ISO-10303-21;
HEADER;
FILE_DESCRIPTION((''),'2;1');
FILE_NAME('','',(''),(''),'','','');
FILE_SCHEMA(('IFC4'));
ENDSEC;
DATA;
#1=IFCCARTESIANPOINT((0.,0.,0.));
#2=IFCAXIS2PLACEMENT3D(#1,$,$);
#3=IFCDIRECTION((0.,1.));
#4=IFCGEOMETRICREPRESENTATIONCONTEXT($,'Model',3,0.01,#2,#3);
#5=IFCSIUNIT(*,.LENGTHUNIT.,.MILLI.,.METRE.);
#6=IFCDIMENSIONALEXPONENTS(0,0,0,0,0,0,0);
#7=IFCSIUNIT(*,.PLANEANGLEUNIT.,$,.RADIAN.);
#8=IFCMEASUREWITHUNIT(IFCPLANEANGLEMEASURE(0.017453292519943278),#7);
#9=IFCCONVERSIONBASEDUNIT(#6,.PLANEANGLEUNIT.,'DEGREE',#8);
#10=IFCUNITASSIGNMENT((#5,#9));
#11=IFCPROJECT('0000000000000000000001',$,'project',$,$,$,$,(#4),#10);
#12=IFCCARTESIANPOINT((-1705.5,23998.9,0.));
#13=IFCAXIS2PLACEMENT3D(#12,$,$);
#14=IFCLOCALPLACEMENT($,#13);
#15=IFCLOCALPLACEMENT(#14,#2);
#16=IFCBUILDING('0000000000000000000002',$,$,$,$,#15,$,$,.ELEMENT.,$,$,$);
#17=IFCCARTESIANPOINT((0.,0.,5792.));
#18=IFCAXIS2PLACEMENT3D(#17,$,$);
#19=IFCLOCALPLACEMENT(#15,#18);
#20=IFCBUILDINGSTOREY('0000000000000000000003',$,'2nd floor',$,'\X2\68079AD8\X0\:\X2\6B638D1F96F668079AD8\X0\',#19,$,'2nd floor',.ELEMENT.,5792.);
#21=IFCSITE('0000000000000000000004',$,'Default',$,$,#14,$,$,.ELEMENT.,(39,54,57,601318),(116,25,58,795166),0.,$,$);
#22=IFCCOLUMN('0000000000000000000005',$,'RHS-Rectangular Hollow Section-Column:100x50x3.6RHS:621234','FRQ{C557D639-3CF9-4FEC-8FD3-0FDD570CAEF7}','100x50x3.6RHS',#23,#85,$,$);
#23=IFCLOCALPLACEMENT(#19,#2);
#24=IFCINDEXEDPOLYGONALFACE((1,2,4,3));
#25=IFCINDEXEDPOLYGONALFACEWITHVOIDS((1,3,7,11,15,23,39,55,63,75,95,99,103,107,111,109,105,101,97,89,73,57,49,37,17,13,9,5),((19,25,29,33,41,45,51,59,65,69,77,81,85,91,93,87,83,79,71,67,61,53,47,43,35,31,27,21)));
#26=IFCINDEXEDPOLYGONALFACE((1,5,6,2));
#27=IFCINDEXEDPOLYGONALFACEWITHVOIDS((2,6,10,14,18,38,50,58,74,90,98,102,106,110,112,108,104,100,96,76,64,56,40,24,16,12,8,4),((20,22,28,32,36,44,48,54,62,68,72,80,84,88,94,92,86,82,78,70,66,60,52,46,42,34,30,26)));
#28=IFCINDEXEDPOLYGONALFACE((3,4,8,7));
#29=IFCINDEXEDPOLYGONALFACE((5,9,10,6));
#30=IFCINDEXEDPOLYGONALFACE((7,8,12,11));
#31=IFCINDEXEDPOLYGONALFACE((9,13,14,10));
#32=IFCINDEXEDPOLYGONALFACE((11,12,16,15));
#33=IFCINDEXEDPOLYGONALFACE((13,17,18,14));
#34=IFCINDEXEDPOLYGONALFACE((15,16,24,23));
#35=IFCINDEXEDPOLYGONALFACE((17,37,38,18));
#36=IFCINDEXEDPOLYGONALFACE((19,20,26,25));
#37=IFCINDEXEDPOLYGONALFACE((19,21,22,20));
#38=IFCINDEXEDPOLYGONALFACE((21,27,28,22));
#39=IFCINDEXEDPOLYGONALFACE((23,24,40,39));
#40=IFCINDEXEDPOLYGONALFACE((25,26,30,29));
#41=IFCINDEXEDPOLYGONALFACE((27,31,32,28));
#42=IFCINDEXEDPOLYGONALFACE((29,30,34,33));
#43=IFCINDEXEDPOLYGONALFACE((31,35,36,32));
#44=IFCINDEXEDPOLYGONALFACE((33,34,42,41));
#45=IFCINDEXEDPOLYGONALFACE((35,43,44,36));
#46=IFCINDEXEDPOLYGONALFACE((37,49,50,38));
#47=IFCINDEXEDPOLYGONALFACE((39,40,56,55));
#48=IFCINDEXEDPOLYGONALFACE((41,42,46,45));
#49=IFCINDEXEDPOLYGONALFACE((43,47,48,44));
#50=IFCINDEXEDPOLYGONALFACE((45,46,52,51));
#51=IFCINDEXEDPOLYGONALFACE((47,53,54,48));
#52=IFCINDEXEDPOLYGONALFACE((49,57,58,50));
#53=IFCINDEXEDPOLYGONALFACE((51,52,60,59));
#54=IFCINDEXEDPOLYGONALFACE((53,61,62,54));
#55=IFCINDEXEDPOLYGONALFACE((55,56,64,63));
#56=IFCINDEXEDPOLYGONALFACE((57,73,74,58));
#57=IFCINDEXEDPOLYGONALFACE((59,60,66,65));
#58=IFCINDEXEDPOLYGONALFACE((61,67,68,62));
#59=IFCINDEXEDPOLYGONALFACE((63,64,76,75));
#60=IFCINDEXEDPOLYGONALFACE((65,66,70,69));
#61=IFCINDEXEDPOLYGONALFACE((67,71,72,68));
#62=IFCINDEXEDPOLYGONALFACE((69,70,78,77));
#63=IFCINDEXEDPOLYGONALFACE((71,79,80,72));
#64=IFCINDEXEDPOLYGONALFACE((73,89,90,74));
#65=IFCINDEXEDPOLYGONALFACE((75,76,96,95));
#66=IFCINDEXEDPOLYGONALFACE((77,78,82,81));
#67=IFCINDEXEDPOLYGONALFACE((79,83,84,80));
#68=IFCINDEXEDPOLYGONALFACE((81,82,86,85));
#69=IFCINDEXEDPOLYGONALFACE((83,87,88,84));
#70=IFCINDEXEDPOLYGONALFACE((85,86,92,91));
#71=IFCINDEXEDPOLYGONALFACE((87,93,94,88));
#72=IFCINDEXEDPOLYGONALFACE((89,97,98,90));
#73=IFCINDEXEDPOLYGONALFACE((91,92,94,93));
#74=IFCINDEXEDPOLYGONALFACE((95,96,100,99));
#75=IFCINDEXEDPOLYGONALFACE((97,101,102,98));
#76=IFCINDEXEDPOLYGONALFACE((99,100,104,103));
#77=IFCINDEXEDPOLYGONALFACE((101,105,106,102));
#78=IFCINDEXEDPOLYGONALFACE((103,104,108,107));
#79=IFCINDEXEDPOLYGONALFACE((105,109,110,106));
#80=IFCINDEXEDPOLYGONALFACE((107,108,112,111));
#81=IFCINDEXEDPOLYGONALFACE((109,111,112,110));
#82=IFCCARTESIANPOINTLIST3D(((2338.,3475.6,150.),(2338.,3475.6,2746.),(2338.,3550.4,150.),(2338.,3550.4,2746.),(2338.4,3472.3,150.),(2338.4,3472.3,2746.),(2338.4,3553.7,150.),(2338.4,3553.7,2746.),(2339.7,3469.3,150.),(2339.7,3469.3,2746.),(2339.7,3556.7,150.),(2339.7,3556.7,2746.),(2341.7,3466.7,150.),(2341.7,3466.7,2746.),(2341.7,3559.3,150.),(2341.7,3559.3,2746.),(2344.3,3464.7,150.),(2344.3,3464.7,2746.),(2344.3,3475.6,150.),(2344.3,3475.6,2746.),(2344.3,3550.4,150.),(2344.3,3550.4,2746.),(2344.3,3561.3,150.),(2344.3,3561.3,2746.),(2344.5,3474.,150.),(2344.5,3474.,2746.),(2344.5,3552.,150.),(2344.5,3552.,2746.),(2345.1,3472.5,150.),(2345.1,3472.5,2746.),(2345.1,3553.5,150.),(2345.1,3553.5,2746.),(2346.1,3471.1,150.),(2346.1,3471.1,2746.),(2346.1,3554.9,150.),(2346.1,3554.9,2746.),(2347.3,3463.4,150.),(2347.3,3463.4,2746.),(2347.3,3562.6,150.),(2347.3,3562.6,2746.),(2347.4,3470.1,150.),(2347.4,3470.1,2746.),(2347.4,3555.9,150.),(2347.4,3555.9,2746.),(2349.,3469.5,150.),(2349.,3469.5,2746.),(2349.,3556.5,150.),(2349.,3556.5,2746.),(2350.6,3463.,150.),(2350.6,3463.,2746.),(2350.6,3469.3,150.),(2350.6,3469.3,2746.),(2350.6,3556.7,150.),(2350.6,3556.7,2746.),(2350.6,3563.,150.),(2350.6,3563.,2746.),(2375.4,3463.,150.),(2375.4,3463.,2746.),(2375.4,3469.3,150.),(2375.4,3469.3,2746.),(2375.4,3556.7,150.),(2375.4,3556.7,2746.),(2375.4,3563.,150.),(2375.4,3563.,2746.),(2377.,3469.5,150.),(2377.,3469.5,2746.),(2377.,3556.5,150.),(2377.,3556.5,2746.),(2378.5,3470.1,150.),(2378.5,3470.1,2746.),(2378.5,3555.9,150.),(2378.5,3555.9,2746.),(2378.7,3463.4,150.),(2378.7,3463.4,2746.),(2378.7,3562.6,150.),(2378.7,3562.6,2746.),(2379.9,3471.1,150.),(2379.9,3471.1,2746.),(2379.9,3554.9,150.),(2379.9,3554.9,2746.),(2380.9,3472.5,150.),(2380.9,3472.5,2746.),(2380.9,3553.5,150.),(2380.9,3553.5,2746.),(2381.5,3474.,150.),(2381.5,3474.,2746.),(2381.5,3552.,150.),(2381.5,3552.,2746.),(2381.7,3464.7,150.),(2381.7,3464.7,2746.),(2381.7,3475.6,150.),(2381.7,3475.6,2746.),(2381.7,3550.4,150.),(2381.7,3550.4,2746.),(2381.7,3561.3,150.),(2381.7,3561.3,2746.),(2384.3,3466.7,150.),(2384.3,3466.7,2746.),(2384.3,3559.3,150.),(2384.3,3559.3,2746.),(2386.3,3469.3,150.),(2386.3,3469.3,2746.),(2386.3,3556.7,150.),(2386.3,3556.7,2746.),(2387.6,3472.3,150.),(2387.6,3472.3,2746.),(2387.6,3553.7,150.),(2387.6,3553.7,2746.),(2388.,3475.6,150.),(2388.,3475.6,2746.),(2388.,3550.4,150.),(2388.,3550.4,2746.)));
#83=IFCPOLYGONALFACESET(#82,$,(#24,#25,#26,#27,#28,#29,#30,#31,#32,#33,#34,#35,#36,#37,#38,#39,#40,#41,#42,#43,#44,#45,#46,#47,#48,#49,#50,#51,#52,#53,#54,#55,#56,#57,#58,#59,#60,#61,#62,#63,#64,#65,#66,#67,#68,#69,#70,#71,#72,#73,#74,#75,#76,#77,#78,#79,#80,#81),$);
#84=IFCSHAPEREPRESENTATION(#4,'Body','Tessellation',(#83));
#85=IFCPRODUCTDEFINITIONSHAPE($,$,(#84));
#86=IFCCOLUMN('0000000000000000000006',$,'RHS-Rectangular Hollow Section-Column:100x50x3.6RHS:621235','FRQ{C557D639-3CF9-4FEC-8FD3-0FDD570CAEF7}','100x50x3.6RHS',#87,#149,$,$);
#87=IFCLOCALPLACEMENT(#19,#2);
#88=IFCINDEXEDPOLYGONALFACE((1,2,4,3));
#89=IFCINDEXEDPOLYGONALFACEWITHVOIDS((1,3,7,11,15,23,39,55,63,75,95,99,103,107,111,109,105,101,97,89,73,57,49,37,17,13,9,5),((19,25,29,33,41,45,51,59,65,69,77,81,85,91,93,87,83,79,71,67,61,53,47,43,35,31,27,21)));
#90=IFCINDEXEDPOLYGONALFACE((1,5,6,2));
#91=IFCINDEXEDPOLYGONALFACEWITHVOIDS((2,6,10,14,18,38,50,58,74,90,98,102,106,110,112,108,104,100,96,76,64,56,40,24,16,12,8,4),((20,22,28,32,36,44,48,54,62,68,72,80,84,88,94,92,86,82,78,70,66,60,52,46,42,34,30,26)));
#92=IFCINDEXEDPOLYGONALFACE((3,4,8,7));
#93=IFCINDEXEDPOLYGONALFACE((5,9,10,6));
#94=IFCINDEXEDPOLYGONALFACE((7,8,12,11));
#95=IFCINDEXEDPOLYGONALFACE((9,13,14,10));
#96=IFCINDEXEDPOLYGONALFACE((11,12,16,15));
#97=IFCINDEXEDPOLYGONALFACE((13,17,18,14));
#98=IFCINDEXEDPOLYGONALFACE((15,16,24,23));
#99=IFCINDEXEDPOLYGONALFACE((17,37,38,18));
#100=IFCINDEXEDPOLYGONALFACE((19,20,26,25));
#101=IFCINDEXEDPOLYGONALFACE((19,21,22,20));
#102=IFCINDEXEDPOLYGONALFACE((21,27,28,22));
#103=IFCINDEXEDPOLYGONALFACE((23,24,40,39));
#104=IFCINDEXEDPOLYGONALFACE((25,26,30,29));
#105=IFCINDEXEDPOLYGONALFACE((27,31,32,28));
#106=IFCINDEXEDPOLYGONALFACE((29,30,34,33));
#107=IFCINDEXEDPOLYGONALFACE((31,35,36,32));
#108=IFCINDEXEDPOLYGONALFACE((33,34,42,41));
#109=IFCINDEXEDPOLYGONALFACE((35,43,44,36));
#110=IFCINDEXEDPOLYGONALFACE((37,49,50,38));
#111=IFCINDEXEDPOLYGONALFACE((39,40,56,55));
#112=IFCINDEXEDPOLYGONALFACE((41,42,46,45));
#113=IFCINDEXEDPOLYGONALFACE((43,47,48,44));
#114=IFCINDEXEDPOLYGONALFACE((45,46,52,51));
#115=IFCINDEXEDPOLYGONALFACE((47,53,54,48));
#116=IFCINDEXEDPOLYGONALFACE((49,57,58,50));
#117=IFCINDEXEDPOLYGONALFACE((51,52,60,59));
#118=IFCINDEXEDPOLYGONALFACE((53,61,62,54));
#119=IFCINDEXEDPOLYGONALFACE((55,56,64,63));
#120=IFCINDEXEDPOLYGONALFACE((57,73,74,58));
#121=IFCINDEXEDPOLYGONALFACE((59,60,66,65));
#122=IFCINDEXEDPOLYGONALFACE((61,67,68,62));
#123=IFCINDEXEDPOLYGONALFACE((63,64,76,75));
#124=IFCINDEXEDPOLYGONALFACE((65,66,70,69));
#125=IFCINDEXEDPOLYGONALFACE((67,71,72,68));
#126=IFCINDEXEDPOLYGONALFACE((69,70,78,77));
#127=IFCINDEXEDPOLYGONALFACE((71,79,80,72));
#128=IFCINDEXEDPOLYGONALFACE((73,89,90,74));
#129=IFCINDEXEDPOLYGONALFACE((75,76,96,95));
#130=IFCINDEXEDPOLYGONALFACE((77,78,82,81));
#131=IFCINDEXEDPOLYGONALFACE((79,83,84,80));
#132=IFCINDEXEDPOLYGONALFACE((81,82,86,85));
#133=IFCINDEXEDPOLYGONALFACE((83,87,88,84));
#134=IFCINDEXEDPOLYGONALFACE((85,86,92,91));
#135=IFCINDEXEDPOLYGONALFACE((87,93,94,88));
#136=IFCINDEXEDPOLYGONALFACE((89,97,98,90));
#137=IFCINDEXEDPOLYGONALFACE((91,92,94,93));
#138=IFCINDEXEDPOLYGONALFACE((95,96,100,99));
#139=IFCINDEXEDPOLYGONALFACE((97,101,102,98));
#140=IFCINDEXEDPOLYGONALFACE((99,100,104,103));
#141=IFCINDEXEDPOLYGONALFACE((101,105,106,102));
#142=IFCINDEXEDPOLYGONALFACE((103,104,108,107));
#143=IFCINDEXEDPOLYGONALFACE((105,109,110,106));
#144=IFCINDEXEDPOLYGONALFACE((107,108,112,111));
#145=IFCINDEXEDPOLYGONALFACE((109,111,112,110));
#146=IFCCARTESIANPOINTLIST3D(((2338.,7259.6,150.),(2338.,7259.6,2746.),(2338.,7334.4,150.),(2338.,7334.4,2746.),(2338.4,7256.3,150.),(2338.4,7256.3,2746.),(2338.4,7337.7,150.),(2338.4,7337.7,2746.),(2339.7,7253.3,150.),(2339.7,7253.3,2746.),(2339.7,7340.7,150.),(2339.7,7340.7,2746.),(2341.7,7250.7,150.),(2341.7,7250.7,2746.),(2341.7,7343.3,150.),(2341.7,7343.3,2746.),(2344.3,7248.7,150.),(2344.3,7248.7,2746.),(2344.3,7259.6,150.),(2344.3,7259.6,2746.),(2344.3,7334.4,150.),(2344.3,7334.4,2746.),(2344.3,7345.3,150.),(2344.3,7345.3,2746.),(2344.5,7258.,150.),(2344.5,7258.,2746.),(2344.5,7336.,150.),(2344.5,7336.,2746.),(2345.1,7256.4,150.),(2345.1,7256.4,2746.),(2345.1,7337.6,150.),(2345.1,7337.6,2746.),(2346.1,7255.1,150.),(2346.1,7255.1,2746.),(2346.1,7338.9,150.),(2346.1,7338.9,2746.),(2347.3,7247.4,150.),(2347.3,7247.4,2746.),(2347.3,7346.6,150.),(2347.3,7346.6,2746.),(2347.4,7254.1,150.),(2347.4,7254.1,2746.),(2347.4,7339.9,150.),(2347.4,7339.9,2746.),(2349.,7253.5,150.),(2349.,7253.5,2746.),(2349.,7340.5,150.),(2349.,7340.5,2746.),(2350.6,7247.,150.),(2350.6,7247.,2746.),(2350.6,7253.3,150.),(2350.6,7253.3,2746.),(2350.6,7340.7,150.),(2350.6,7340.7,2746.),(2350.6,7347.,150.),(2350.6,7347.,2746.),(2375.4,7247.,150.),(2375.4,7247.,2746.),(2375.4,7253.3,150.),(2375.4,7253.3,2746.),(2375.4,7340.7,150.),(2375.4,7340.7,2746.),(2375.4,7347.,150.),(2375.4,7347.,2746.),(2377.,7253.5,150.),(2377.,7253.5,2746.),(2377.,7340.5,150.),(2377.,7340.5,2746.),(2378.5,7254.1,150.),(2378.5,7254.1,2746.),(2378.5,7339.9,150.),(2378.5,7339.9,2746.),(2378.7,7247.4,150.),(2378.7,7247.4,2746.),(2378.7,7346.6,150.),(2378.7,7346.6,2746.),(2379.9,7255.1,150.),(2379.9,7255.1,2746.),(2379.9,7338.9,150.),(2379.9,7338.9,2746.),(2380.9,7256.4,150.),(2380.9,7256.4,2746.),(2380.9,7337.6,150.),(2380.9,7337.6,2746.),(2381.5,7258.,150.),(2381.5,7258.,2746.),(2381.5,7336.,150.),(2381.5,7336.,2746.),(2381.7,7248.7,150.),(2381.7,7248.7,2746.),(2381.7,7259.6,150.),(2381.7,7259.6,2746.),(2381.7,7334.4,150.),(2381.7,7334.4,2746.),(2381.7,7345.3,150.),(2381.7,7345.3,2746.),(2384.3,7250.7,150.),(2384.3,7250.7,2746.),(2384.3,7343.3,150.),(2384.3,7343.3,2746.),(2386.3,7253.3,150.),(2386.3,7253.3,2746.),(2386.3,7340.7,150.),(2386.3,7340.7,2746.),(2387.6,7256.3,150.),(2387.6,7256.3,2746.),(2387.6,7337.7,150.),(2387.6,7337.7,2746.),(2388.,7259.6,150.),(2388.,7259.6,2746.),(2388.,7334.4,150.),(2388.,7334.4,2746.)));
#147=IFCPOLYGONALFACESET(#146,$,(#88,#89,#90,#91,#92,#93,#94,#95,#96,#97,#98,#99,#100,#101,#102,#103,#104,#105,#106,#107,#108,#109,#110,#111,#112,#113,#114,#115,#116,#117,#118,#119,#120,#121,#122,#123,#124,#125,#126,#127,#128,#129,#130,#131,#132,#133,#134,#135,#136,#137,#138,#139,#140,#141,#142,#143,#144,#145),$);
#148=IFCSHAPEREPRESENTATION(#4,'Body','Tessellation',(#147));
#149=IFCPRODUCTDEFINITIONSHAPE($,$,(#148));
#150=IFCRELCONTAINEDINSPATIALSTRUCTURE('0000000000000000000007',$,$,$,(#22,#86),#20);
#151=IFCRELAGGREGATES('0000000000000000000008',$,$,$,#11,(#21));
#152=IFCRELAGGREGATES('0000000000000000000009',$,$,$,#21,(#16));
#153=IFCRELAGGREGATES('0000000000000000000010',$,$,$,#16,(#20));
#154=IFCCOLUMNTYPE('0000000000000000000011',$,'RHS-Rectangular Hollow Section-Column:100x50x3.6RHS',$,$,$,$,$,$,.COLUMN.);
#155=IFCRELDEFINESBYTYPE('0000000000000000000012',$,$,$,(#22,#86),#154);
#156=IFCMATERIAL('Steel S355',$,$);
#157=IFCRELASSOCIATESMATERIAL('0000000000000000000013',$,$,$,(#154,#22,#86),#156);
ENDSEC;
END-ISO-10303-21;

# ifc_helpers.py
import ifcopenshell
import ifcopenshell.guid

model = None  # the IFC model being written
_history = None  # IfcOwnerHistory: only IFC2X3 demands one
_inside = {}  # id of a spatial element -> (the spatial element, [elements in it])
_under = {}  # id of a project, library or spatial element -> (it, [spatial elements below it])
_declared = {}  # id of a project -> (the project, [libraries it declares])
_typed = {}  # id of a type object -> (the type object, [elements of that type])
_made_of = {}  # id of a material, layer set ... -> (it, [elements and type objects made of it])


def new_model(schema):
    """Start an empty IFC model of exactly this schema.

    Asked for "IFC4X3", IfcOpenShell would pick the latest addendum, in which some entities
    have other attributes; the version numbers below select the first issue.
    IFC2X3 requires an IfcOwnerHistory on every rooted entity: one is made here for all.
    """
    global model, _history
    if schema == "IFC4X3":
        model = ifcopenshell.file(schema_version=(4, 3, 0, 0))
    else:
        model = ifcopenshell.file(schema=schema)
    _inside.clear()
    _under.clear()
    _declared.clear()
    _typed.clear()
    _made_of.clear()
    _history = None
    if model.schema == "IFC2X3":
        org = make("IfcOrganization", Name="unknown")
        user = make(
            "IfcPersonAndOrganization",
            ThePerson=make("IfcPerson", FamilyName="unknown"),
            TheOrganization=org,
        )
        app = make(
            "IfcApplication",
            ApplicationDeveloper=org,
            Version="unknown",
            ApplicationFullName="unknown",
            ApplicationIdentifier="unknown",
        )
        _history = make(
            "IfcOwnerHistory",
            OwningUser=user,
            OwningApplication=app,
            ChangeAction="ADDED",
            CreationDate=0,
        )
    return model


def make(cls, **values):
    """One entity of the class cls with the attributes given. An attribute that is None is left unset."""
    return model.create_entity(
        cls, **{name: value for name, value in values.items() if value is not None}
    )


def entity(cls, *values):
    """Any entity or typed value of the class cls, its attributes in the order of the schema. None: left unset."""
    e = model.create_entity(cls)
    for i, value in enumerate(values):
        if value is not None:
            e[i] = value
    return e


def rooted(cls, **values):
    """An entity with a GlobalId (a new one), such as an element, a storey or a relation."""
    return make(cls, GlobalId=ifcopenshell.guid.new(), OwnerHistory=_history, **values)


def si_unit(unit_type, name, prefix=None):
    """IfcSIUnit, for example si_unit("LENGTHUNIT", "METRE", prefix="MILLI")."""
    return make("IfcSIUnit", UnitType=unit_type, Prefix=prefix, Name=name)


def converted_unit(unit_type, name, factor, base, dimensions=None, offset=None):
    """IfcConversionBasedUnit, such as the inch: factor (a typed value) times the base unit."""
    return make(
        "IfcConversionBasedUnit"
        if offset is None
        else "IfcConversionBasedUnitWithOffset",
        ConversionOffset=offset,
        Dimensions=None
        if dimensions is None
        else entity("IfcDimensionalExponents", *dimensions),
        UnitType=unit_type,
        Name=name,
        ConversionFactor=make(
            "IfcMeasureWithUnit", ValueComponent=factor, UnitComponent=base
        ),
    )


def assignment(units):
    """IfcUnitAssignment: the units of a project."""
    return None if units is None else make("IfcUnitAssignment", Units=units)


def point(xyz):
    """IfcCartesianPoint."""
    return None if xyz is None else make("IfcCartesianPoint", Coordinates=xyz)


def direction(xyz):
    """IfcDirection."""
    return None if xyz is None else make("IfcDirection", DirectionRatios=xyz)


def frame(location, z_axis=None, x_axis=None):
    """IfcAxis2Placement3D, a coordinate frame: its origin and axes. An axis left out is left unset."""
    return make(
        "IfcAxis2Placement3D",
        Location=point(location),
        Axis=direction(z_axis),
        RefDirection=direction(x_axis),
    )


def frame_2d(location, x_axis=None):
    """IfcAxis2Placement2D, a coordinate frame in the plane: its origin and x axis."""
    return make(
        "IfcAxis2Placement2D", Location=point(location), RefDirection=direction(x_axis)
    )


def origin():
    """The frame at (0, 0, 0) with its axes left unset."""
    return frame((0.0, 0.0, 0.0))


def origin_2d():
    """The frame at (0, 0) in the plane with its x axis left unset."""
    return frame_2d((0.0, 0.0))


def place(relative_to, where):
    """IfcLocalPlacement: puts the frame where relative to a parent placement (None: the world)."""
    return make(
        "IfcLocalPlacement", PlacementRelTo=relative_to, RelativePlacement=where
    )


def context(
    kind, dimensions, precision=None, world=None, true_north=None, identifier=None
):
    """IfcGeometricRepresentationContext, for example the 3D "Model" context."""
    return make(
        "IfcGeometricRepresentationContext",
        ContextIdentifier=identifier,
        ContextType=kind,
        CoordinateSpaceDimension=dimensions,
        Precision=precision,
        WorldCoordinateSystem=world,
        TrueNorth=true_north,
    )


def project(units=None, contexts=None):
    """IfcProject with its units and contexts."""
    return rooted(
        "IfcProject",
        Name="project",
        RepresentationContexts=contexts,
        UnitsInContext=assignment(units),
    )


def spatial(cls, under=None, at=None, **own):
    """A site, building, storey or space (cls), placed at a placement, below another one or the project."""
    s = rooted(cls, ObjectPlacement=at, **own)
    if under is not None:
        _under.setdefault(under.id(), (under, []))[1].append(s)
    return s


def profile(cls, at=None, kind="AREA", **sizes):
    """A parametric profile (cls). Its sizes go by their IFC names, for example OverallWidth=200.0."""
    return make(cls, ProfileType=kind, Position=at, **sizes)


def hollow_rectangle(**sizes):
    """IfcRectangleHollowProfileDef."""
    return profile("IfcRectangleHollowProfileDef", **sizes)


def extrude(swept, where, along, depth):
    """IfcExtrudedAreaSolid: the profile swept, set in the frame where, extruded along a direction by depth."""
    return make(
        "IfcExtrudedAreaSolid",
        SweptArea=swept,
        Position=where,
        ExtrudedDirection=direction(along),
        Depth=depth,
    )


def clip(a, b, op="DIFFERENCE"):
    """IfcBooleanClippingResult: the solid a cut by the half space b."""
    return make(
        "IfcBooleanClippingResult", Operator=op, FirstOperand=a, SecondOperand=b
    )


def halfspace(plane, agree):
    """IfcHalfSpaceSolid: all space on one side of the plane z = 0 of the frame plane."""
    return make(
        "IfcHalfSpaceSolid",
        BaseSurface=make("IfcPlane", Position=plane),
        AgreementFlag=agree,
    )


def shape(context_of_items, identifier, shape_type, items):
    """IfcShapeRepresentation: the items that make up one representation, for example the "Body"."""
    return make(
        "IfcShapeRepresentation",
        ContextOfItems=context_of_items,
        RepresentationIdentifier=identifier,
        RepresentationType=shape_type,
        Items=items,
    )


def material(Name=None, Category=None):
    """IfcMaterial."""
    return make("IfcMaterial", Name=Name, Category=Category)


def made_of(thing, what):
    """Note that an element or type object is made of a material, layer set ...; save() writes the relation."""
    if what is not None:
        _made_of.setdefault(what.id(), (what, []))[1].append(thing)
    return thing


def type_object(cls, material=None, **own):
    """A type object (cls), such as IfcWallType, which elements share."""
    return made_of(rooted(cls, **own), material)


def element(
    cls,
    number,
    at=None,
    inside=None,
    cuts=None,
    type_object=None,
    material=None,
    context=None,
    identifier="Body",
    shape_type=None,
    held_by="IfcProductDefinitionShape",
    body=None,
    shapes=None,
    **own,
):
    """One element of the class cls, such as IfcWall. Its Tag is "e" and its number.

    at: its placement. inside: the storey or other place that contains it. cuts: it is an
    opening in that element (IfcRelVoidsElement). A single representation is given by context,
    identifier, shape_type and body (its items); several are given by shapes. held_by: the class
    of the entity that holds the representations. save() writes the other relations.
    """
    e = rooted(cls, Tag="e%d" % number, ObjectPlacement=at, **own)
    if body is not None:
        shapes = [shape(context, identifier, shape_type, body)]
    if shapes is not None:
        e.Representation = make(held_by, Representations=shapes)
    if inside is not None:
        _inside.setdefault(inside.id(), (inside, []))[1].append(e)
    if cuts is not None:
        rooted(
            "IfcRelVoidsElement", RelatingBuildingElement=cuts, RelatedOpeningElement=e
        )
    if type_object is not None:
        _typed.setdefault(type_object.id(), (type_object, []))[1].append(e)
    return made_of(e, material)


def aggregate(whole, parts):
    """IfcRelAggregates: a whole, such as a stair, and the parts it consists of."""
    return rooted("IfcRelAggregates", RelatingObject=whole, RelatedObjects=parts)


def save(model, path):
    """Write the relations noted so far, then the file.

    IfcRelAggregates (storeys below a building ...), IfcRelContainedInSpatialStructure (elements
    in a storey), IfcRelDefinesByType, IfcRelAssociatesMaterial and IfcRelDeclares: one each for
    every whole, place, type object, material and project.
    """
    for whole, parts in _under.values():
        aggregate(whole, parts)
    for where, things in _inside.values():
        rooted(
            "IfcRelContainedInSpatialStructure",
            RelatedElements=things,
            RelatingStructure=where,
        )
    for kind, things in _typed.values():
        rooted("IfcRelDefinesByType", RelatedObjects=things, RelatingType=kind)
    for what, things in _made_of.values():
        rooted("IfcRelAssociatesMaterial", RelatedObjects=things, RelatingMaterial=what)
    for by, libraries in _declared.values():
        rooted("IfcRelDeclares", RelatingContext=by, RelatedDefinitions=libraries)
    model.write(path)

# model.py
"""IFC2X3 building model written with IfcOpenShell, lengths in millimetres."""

from ifc_helpers import new_model, entity, si_unit, converted_unit, direction, frame, origin, origin_2d, place, context, project, spatial, hollow_rectangle, extrude, clip, halfspace, material, type_object, element, save


model = new_model("IFC2X3")

# Units and contexts
model_context = context("Model", 3, precision=0.01, world=origin(), true_north=direction((0.0, 1.0)))
ifc_project = project(units=[si_unit("LENGTHUNIT", "METRE", prefix="MILLI"), converted_unit("PLANEANGLEUNIT", "DEGREE", entity("IfcPlaneAngleMeasure", 0.017453292519943278), si_unit("PLANEANGLEUNIT", "RADIAN"), dimensions=[0, 0, 0, 0, 0, 0, 0])], contexts=[model_context])

# Site, building, storey
site_placement = place(None, frame((-1705.5, 23998.9, 0.0)))
site = spatial("IfcSite", under=ifc_project, at=site_placement, Name="Default", CompositionType="ELEMENT", RefLatitude=(39, 54, 57, 601318), RefLongitude=(116, 25, 58, 795166), RefElevation=0.0)
building_placement = place(site_placement, origin())
building = spatial("IfcBuilding", under=site, at=building_placement, CompositionType="ELEMENT")
storey_placement = place(building_placement, frame((0.0, 0.0, 5792.0)))
storey = spatial("IfcBuildingStorey", under=building, at=storey_placement, Name="2nd floor", ObjectType="标高:正负零标高", LongName="2nd floor", CompositionType="ELEMENT", Elevation=5792.0)

# Columns
ifc_material_1 = material(Name="Steel S355")
column_type_1 = type_object("IfcColumnType", Name="RHS-Rectangular Hollow Section-Column:100x50x3.6RHS", PredefinedType="COLUMN", material=ifc_material_1)
column_1_placement = place(storey_placement, frame((2363.0, 3513.0, 2746.0), z_axis=(0.0, 0.0, 1.0), x_axis=(-1.0, 0.0, 0.0)))
element("IfcColumn", 1, at=column_1_placement, inside=storey, type_object=column_type_1, material=ifc_material_1, Name="RHS-Rectangular Hollow Section-Column:100x50x3.6RHS:621234", Description="FRQ{C557D639-3CF9-4FEC-8FD3-0FDD570CAEF7}", ObjectType="100x50x3.6RHS", context=model_context, shape_type="Clipping", body=[
    clip(extrude(hollow_rectangle(XDim=50.0, YDim=100.0, WallThickness=6.3, InnerFilletRadius=6.3, OuterFilletRadius=12.6, at=origin_2d()), origin(), (0.0, 0.0, -1.0), 2651.9), halfspace(frame((2363.0, 3513.0, -2596.0), z_axis=(0.0, 0.0, 1.0), x_axis=(-1.0, 0.0, 0.0)), True)),
])
column_2_placement = place(storey_placement, frame((2363.0, 7297.0, 2746.0), z_axis=(0.0, 0.0, 1.0), x_axis=(-1.0, 0.0, 0.0)))
element("IfcColumn", 2, at=column_2_placement, inside=storey, type_object=column_type_1, material=ifc_material_1, Name="RHS-Rectangular Hollow Section-Column:100x50x3.6RHS:621235", Description="FRQ{C557D639-3CF9-4FEC-8FD3-0FDD570CAEF7}", ObjectType="100x50x3.6RHS", context=model_context, shape_type="Clipping", body=[
    clip(extrude(hollow_rectangle(XDim=50.0, YDim=100.0, WallThickness=6.3, InnerFilletRadius=6.3, OuterFilletRadius=12.6, at=origin_2d()), origin(), (0.0, 0.0, -1.0), 2651.9), halfspace(frame((2363.0, 7297.0, -2596.0), z_axis=(0.0, 0.0, 1.0), x_axis=(-1.0, 0.0, 0.0)), True)),
])

save(model, "model.ifc")
